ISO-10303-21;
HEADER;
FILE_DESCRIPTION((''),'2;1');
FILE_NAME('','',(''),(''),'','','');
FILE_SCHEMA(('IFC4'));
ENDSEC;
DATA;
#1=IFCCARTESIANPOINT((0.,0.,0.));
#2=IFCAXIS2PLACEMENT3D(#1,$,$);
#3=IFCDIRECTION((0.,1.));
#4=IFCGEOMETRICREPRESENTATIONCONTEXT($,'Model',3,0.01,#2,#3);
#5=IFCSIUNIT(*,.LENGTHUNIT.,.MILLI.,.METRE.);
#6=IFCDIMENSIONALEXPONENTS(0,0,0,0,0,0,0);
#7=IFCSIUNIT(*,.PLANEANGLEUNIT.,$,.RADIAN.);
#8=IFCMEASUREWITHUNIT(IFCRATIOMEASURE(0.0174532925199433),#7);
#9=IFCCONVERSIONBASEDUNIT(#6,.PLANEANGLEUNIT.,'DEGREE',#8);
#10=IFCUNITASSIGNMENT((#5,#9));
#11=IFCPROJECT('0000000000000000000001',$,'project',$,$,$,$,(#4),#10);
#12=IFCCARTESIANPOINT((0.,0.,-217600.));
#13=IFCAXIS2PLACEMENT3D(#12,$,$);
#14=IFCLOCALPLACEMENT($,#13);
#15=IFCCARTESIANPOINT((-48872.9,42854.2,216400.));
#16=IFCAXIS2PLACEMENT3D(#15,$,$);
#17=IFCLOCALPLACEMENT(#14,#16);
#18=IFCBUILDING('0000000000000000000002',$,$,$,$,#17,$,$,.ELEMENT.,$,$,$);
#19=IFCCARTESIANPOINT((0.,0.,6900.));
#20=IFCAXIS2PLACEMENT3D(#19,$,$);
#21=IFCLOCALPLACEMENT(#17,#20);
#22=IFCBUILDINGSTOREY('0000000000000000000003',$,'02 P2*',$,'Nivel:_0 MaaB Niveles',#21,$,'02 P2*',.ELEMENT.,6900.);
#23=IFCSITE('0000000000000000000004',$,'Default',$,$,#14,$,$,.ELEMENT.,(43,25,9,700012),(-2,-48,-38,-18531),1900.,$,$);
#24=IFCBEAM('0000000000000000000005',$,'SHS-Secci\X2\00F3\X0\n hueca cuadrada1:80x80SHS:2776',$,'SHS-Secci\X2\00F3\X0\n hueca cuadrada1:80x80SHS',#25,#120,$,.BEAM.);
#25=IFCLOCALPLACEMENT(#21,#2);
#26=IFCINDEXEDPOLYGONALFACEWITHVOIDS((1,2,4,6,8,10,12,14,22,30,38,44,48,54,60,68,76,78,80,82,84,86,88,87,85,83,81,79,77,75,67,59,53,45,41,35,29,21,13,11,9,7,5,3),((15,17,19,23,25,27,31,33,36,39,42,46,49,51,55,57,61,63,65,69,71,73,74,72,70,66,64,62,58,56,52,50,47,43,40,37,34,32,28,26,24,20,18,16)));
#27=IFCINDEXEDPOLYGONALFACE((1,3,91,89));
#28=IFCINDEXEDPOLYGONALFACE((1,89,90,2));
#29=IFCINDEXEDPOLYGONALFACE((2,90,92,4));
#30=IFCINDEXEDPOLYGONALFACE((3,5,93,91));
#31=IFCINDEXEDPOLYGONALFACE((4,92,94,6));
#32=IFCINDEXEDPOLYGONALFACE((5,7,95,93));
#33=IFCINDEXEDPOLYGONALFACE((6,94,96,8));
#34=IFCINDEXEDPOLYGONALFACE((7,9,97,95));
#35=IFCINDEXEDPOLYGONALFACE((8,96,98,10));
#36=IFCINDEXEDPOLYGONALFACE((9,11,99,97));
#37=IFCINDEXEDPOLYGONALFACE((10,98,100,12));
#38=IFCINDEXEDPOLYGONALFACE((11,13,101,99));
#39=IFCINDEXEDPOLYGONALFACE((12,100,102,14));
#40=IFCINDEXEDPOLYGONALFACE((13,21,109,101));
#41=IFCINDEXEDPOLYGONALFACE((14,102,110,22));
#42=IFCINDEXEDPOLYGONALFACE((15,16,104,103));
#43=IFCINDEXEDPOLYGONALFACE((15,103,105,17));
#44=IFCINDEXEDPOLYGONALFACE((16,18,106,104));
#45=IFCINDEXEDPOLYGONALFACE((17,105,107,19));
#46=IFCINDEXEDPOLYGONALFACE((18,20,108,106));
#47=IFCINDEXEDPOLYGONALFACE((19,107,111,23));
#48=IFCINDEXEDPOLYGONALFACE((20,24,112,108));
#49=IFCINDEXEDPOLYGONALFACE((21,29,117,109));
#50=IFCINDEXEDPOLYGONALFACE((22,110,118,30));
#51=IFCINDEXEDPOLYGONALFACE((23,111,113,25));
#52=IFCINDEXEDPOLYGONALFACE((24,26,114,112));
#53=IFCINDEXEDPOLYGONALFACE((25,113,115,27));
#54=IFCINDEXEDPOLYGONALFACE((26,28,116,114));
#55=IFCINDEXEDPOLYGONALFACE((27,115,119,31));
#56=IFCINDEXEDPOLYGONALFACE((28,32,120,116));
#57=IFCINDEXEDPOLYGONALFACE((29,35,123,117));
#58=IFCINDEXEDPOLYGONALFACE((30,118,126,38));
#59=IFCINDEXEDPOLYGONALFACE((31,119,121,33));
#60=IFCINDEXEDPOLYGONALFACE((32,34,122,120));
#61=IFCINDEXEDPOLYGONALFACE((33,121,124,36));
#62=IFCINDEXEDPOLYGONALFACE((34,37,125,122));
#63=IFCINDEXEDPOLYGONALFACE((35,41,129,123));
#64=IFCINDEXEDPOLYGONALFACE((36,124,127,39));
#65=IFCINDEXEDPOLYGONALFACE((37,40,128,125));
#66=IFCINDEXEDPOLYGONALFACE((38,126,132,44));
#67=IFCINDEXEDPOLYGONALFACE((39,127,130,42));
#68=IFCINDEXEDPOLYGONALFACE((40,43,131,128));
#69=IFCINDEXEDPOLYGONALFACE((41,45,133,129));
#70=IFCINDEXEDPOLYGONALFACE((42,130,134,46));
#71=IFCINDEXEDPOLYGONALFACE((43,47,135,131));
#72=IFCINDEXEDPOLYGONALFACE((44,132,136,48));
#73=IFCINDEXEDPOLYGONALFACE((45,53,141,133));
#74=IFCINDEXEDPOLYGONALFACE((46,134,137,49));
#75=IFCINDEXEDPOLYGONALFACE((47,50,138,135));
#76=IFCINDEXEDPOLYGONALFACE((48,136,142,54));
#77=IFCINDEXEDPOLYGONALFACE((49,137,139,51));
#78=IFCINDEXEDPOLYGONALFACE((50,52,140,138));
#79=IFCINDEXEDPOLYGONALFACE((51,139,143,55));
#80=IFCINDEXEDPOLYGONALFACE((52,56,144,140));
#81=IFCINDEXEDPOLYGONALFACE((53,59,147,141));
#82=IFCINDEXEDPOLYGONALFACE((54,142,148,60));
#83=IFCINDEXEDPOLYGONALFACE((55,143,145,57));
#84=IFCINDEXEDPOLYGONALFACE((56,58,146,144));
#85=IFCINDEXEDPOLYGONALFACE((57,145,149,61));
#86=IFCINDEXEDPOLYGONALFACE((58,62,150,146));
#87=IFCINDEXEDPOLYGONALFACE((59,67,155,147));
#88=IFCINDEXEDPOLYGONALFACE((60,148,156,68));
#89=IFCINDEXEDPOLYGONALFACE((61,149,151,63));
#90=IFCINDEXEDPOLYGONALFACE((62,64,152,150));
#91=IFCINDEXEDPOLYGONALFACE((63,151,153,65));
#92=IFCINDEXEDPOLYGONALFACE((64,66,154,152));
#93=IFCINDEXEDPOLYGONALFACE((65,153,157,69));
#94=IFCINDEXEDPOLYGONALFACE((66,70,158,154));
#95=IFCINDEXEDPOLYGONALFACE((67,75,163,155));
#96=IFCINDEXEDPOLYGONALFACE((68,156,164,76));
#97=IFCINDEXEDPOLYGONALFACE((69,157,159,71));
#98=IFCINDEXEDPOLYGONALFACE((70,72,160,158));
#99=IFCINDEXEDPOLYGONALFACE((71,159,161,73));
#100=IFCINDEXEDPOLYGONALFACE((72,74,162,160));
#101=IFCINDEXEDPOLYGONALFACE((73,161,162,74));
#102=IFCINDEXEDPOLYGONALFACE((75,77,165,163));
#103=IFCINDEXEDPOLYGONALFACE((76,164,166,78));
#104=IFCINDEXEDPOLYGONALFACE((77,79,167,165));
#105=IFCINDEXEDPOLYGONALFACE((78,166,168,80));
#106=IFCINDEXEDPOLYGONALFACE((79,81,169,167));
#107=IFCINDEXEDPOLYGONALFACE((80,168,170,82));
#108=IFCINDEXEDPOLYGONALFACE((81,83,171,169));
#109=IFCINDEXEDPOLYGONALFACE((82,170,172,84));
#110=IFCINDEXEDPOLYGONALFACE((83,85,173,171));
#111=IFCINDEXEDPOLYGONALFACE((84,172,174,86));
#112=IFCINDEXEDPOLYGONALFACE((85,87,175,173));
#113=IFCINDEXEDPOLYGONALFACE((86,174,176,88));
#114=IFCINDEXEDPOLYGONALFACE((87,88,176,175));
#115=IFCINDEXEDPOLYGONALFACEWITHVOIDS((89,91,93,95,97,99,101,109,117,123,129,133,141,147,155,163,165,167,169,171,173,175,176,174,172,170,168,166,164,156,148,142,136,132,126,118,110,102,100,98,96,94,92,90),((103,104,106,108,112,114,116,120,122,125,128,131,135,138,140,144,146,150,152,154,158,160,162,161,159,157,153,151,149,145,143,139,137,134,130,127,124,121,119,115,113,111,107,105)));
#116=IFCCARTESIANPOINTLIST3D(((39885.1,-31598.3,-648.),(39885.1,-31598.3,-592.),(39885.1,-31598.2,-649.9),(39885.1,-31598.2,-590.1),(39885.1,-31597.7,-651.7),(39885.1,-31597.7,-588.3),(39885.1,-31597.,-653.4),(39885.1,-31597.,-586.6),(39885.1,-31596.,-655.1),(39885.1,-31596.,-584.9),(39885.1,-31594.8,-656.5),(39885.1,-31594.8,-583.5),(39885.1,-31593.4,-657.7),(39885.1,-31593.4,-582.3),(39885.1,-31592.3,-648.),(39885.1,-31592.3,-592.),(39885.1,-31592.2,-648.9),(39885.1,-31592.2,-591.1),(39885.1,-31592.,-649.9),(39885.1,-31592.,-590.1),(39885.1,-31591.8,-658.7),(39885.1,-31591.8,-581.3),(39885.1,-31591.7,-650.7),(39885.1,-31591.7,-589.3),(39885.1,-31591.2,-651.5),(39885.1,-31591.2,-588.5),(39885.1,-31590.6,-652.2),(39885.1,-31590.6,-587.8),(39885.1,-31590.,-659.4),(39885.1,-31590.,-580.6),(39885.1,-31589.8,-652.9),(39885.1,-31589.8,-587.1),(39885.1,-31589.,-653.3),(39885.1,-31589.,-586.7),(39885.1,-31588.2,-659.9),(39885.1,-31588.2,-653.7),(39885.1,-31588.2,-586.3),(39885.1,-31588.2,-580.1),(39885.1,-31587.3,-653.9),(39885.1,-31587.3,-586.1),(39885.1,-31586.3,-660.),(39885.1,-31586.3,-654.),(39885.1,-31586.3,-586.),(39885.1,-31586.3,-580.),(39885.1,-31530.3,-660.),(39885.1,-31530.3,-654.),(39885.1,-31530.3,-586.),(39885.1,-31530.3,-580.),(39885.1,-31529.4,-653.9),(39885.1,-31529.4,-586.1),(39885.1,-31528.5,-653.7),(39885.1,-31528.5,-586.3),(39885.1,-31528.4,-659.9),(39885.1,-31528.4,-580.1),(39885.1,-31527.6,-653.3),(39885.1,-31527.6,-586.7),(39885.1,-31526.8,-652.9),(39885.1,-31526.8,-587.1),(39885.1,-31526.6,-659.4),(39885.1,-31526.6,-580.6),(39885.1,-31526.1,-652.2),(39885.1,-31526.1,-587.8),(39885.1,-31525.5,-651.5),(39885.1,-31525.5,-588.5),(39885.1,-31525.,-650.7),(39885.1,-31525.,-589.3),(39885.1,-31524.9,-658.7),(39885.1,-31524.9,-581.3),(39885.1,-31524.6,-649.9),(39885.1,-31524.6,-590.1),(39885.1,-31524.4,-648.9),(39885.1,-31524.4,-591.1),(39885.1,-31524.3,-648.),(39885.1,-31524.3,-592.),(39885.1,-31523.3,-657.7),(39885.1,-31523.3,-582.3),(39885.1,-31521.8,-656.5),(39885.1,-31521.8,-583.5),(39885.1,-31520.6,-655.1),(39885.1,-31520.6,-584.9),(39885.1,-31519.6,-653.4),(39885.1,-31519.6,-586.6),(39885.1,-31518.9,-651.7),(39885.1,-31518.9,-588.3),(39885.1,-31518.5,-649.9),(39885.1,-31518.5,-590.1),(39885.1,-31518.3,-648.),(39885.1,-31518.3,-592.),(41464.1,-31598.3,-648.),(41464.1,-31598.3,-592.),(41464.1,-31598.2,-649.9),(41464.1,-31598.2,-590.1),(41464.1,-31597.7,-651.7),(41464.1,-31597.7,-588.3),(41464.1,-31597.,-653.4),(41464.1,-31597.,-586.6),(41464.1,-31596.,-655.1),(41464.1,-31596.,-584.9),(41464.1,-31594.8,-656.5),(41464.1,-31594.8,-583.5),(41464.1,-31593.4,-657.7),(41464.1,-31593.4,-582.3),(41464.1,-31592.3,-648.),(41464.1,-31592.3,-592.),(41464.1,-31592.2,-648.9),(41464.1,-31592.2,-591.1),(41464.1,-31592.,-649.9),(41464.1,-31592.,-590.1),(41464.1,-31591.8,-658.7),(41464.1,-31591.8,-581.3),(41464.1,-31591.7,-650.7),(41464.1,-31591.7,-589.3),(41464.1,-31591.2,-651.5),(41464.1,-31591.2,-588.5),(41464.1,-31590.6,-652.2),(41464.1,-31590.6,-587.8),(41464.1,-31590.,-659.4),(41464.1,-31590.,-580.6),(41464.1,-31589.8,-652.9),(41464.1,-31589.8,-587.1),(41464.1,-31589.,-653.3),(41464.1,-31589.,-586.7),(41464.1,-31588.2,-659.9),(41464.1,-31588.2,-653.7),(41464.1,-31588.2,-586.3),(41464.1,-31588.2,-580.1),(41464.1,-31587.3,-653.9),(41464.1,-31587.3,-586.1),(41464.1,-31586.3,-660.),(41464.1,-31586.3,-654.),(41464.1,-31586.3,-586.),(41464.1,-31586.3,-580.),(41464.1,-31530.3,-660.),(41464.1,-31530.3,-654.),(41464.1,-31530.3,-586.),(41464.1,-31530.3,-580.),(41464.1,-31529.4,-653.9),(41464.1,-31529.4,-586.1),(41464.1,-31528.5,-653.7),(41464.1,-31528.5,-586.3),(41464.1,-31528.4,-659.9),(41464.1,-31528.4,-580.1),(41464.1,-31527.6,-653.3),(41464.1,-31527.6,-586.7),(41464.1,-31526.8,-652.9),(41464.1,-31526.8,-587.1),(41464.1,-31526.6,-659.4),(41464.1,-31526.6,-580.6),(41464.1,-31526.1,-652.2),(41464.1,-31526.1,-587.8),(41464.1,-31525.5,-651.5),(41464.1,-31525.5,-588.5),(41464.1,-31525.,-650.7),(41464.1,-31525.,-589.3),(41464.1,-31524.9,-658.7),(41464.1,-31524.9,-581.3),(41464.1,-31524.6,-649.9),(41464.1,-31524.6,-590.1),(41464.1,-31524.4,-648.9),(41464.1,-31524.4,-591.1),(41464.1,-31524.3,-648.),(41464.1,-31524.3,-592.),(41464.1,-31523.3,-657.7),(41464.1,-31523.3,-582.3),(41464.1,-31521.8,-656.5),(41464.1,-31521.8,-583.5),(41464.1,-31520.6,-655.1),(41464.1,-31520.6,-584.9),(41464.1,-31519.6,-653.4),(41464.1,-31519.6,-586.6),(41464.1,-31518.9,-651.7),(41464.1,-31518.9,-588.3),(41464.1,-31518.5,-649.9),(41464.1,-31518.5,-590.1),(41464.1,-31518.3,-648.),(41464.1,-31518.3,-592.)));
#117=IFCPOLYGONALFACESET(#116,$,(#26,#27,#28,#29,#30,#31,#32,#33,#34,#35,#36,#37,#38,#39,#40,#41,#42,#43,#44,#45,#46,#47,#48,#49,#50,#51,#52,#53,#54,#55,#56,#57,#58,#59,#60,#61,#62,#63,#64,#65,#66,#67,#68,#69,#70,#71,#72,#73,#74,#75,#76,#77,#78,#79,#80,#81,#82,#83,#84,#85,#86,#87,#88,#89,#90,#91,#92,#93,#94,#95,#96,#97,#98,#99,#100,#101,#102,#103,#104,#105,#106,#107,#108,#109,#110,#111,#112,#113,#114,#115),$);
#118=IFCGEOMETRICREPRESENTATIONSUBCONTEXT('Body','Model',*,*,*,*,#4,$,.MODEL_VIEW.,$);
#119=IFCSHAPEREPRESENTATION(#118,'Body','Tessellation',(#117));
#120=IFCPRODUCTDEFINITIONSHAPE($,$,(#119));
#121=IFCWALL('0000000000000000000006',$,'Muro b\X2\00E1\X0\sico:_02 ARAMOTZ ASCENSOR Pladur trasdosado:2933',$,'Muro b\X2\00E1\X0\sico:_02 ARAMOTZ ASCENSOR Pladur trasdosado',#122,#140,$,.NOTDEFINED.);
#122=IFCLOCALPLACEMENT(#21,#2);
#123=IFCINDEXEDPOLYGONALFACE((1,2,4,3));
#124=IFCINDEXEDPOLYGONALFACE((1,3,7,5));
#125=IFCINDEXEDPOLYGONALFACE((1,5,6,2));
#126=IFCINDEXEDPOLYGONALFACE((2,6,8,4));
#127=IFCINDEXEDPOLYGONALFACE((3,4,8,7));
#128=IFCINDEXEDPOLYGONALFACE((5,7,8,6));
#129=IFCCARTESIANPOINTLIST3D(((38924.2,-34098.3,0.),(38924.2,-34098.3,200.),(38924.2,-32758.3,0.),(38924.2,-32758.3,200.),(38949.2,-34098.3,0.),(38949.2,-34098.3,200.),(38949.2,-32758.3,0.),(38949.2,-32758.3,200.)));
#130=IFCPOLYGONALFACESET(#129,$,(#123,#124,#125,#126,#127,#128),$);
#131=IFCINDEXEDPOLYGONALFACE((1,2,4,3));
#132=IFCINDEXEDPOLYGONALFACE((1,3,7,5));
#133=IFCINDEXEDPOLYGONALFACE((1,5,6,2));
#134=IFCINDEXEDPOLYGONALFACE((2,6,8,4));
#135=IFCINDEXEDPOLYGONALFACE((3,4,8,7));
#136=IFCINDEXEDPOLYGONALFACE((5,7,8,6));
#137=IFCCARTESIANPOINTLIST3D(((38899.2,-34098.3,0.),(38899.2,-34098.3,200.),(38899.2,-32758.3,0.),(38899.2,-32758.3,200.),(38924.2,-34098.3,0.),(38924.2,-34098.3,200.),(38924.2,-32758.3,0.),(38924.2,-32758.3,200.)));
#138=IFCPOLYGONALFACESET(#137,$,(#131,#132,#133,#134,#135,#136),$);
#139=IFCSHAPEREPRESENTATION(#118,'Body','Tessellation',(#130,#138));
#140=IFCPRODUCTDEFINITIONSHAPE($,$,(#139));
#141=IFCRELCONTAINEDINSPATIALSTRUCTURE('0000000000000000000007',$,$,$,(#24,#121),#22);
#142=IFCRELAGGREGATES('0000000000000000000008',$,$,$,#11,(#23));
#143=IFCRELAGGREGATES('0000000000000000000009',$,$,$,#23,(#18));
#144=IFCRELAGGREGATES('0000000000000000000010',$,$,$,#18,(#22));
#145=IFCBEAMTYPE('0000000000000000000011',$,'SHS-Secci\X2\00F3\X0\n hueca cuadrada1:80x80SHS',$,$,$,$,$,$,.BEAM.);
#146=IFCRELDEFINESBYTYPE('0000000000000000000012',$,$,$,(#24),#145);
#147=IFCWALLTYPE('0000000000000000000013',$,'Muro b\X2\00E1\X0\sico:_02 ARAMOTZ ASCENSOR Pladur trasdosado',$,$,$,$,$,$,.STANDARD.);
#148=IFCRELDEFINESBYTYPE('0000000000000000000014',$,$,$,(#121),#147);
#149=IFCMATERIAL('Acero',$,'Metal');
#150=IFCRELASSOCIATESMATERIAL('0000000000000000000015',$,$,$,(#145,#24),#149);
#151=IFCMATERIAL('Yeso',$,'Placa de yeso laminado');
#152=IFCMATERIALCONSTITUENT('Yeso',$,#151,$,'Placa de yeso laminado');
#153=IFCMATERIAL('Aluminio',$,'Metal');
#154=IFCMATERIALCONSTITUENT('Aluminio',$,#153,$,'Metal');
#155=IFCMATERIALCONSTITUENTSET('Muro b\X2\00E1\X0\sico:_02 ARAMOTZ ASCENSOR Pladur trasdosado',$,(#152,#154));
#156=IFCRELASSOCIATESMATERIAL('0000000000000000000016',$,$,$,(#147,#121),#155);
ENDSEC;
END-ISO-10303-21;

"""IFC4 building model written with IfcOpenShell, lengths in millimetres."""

from ifc_helpers import new_model, entity, si_unit, converted_unit, direction, frame, origin, place, context, subcontext, project, spatial, indexed_curve, outline, extrude, source, transform, mapped, material, constituent, constituent_set, type_object, type_shapes, element, save


model = new_model("IFC4")

# Units and contexts
model_context = context("Model", 3, precision=0.01, world=origin(), true_north=direction((0.0, 1.0)))
body_context = subcontext(model_context, "Body", "Model", "MODEL_VIEW")
ifc_project = project(units=[si_unit("LENGTHUNIT", "METRE", prefix="MILLI"), converted_unit("PLANEANGLEUNIT", "DEGREE", entity("IfcRatioMeasure", 0.0174532925199433), si_unit("PLANEANGLEUNIT", "RADIAN"), dimensions=[0, 0, 0, 0, 0, 0, 0])], contexts=[model_context])

# Site, building, storey
site_placement = place(None, frame((0.0, 0.0, -217600.0)))
site = spatial("IfcSite", under=ifc_project, at=site_placement, Name="Default", CompositionType="ELEMENT", RefLatitude=(43, 25, 9, 700012), RefLongitude=(-2, -48, -38, -18531), RefElevation=1900.0)
building_placement = place(site_placement, frame((-48872.9, 42854.2, 216400.0)))
building = spatial("IfcBuilding", under=site, at=building_placement, CompositionType="ELEMENT")
storey_placement = place(building_placement, frame((0.0, 0.0, 6900.0)))
storey = spatial("IfcBuildingStorey", under=building, at=storey_placement, Name="02 P2*", ObjectType="Nivel:_0 MaaB Niveles", LongName="02 P2*", CompositionType="ELEMENT", Elevation=6900.0)

# Shared definitions
ifc_material_1 = material(Name="Acero", Category="Metal")

# Beam
beam_type = type_object("IfcBeamType", Name="SHS-Sección hueca cuadrada1:80x80SHS", PredefinedType="BEAM", material=ifc_material_1)
shared_shape_1 = source(origin(), body_context, "Body", "SweptSolid", [
    extrude(outline(indexed_curve([(-40.0, -28.0), (-39.9, -29.9), (-39.4, -31.7), (-38.7, -33.4), (-37.7, -35.1), (-36.5, -36.5), (-35.1, -37.7), (-33.4, -38.7), (-31.7, -39.4), (-29.9, -39.9), (-28.0, -40.0), (28.0, -40.0), (29.9, -39.9), (31.7, -39.4), (33.4, -38.7), (35.1, -37.7), (36.5, -36.5), (37.7, -35.1), (38.7, -33.4), (39.4, -31.7), (39.9, -29.9), (40.0, -28.0), (40.0, 28.0), (39.9, 29.9), (39.4, 31.7), (38.7, 33.4), (37.7, 35.1), (36.5, 36.5), (35.1, 37.7), (33.4, 38.7), (31.7, 39.4), (29.9, 39.9), (28.0, 40.0), (-28.0, 40.0), (-29.9, 39.9), (-31.7, 39.4), (-33.4, 38.7), (-35.1, 37.7), (-36.5, 36.5), (-37.7, 35.1), (-38.7, 33.4), (-39.4, 31.7), (-39.9, 29.9), (-40.0, 28.0), (-40.0, -28.0)], self_intersect=False), holes=[indexed_curve([(28.0, -34.0), (-28.0, -34.0), (-28.9, -33.9), (-29.9, -33.7), (-30.7, -33.3), (-31.5, -32.9), (-32.2, -32.2), (-32.9, -31.5), (-33.3, -30.7), (-33.7, -29.9), (-33.9, -28.9), (-34.0, -28.0), (-34.0, 28.0), (-33.9, 28.9), (-33.7, 29.9), (-33.3, 30.7), (-32.9, 31.5), (-32.2, 32.2), (-31.5, 32.9), (-30.7, 33.3), (-29.9, 33.7), (-28.9, 33.9), (-28.0, 34.0), (28.0, 34.0), (28.9, 33.9), (29.9, 33.7), (30.7, 33.3), (31.5, 32.9), (32.2, 32.2), (32.9, 31.5), (33.3, 30.7), (33.7, 29.9), (33.9, 28.9), (34.0, 28.0), (34.0, -28.0), (33.9, -28.9), (33.7, -29.9), (33.3, -30.7), (32.9, -31.5), (32.2, -32.2), (31.5, -32.9), (30.7, -33.3), (29.9, -33.7), (28.9, -33.9), (28.0, -34.0)], self_intersect=False)]), frame((-733.0, 0.0, 0.0), z_axis=(1.0, 0.0, 0.0), x_axis=(0.0, -1.0, 0.0)), (0.0, 0.0, 1.0), 1579.0),
])
type_shapes(beam_type, [shared_shape_1])
beam_placement = place(storey_placement, frame((40731.1, -31558.3, -620.0), z_axis=(0.0, 0.0, 1.0), x_axis=(-1.0, 0.0, 0.0)))
element("IfcBeam", 1, at=beam_placement, inside=storey, type_object=beam_type, material=ifc_material_1, Name="SHS-Sección hueca cuadrada1:80x80SHS:2776", ObjectType="SHS-Sección hueca cuadrada1:80x80SHS", PredefinedType="BEAM", context=body_context, shape_type="MappedRepresentation", body=[
    mapped(shared_shape_1, transform((0.0, 0.0, 0.0), scale=1.0)),
])

# Wall
ifc_material_2 = material(Name="Yeso", Category="Placa de yeso laminado")
ifc_material_3 = material(Name="Aluminio", Category="Metal")
ifc_constituent_1 = constituent(ifc_material_2, Name="Yeso", Category="Placa de yeso laminado")
ifc_constituent_2 = constituent(ifc_material_3, Name="Aluminio", Category="Metal")
ifc_constituent_set_1 = constituent_set(constituents=[ifc_constituent_1, ifc_constituent_2], Name="Muro básico:_02 ARAMOTZ ASCENSOR Pladur trasdosado")
wall_type_1 = type_object("IfcWallType", Name="Muro básico:_02 ARAMOTZ ASCENSOR Pladur trasdosado", PredefinedType="STANDARD", material=ifc_constituent_set_1)
wall_1_placement = place(storey_placement, frame((38924.2, -32758.3, 0.0), z_axis=(0.0, 0.0, 1.0), x_axis=(0.0, -1.0, 0.0)))
element("IfcWall", 2, at=wall_1_placement, inside=storey, type_object=wall_type_1, material=ifc_constituent_set_1, Name="Muro básico:_02 ARAMOTZ ASCENSOR Pladur trasdosado:2933", ObjectType="Muro básico:_02 ARAMOTZ ASCENSOR Pladur trasdosado", PredefinedType="NOTDEFINED", context=body_context, shape_type="SweptSolid", body=[
    extrude(outline(indexed_curve([(-670.0, -12.5), (670.0, -12.5), (670.0, 12.5), (-670.0, 12.5), (-670.0, -12.5)], self_intersect=False)), frame((670.0, 12.5, 0.0), z_axis=(0.0, 0.0, 1.0), x_axis=(-1.0, 0.0, 0.0)), (0.0, 0.0, 1.0), 200.0),
    extrude(outline(indexed_curve([(-12.5, -670.0), (12.5, -670.0), (12.5, 670.0), (-12.5, 670.0), (-12.5, -670.0)], self_intersect=False)), frame((670.0, -12.5, 0.0), z_axis=(0.0, 0.0, 1.0), x_axis=(0.0, -1.0, 0.0)), (0.0, 0.0, 1.0), 200.0),
])

save(model, "model.ifc")
